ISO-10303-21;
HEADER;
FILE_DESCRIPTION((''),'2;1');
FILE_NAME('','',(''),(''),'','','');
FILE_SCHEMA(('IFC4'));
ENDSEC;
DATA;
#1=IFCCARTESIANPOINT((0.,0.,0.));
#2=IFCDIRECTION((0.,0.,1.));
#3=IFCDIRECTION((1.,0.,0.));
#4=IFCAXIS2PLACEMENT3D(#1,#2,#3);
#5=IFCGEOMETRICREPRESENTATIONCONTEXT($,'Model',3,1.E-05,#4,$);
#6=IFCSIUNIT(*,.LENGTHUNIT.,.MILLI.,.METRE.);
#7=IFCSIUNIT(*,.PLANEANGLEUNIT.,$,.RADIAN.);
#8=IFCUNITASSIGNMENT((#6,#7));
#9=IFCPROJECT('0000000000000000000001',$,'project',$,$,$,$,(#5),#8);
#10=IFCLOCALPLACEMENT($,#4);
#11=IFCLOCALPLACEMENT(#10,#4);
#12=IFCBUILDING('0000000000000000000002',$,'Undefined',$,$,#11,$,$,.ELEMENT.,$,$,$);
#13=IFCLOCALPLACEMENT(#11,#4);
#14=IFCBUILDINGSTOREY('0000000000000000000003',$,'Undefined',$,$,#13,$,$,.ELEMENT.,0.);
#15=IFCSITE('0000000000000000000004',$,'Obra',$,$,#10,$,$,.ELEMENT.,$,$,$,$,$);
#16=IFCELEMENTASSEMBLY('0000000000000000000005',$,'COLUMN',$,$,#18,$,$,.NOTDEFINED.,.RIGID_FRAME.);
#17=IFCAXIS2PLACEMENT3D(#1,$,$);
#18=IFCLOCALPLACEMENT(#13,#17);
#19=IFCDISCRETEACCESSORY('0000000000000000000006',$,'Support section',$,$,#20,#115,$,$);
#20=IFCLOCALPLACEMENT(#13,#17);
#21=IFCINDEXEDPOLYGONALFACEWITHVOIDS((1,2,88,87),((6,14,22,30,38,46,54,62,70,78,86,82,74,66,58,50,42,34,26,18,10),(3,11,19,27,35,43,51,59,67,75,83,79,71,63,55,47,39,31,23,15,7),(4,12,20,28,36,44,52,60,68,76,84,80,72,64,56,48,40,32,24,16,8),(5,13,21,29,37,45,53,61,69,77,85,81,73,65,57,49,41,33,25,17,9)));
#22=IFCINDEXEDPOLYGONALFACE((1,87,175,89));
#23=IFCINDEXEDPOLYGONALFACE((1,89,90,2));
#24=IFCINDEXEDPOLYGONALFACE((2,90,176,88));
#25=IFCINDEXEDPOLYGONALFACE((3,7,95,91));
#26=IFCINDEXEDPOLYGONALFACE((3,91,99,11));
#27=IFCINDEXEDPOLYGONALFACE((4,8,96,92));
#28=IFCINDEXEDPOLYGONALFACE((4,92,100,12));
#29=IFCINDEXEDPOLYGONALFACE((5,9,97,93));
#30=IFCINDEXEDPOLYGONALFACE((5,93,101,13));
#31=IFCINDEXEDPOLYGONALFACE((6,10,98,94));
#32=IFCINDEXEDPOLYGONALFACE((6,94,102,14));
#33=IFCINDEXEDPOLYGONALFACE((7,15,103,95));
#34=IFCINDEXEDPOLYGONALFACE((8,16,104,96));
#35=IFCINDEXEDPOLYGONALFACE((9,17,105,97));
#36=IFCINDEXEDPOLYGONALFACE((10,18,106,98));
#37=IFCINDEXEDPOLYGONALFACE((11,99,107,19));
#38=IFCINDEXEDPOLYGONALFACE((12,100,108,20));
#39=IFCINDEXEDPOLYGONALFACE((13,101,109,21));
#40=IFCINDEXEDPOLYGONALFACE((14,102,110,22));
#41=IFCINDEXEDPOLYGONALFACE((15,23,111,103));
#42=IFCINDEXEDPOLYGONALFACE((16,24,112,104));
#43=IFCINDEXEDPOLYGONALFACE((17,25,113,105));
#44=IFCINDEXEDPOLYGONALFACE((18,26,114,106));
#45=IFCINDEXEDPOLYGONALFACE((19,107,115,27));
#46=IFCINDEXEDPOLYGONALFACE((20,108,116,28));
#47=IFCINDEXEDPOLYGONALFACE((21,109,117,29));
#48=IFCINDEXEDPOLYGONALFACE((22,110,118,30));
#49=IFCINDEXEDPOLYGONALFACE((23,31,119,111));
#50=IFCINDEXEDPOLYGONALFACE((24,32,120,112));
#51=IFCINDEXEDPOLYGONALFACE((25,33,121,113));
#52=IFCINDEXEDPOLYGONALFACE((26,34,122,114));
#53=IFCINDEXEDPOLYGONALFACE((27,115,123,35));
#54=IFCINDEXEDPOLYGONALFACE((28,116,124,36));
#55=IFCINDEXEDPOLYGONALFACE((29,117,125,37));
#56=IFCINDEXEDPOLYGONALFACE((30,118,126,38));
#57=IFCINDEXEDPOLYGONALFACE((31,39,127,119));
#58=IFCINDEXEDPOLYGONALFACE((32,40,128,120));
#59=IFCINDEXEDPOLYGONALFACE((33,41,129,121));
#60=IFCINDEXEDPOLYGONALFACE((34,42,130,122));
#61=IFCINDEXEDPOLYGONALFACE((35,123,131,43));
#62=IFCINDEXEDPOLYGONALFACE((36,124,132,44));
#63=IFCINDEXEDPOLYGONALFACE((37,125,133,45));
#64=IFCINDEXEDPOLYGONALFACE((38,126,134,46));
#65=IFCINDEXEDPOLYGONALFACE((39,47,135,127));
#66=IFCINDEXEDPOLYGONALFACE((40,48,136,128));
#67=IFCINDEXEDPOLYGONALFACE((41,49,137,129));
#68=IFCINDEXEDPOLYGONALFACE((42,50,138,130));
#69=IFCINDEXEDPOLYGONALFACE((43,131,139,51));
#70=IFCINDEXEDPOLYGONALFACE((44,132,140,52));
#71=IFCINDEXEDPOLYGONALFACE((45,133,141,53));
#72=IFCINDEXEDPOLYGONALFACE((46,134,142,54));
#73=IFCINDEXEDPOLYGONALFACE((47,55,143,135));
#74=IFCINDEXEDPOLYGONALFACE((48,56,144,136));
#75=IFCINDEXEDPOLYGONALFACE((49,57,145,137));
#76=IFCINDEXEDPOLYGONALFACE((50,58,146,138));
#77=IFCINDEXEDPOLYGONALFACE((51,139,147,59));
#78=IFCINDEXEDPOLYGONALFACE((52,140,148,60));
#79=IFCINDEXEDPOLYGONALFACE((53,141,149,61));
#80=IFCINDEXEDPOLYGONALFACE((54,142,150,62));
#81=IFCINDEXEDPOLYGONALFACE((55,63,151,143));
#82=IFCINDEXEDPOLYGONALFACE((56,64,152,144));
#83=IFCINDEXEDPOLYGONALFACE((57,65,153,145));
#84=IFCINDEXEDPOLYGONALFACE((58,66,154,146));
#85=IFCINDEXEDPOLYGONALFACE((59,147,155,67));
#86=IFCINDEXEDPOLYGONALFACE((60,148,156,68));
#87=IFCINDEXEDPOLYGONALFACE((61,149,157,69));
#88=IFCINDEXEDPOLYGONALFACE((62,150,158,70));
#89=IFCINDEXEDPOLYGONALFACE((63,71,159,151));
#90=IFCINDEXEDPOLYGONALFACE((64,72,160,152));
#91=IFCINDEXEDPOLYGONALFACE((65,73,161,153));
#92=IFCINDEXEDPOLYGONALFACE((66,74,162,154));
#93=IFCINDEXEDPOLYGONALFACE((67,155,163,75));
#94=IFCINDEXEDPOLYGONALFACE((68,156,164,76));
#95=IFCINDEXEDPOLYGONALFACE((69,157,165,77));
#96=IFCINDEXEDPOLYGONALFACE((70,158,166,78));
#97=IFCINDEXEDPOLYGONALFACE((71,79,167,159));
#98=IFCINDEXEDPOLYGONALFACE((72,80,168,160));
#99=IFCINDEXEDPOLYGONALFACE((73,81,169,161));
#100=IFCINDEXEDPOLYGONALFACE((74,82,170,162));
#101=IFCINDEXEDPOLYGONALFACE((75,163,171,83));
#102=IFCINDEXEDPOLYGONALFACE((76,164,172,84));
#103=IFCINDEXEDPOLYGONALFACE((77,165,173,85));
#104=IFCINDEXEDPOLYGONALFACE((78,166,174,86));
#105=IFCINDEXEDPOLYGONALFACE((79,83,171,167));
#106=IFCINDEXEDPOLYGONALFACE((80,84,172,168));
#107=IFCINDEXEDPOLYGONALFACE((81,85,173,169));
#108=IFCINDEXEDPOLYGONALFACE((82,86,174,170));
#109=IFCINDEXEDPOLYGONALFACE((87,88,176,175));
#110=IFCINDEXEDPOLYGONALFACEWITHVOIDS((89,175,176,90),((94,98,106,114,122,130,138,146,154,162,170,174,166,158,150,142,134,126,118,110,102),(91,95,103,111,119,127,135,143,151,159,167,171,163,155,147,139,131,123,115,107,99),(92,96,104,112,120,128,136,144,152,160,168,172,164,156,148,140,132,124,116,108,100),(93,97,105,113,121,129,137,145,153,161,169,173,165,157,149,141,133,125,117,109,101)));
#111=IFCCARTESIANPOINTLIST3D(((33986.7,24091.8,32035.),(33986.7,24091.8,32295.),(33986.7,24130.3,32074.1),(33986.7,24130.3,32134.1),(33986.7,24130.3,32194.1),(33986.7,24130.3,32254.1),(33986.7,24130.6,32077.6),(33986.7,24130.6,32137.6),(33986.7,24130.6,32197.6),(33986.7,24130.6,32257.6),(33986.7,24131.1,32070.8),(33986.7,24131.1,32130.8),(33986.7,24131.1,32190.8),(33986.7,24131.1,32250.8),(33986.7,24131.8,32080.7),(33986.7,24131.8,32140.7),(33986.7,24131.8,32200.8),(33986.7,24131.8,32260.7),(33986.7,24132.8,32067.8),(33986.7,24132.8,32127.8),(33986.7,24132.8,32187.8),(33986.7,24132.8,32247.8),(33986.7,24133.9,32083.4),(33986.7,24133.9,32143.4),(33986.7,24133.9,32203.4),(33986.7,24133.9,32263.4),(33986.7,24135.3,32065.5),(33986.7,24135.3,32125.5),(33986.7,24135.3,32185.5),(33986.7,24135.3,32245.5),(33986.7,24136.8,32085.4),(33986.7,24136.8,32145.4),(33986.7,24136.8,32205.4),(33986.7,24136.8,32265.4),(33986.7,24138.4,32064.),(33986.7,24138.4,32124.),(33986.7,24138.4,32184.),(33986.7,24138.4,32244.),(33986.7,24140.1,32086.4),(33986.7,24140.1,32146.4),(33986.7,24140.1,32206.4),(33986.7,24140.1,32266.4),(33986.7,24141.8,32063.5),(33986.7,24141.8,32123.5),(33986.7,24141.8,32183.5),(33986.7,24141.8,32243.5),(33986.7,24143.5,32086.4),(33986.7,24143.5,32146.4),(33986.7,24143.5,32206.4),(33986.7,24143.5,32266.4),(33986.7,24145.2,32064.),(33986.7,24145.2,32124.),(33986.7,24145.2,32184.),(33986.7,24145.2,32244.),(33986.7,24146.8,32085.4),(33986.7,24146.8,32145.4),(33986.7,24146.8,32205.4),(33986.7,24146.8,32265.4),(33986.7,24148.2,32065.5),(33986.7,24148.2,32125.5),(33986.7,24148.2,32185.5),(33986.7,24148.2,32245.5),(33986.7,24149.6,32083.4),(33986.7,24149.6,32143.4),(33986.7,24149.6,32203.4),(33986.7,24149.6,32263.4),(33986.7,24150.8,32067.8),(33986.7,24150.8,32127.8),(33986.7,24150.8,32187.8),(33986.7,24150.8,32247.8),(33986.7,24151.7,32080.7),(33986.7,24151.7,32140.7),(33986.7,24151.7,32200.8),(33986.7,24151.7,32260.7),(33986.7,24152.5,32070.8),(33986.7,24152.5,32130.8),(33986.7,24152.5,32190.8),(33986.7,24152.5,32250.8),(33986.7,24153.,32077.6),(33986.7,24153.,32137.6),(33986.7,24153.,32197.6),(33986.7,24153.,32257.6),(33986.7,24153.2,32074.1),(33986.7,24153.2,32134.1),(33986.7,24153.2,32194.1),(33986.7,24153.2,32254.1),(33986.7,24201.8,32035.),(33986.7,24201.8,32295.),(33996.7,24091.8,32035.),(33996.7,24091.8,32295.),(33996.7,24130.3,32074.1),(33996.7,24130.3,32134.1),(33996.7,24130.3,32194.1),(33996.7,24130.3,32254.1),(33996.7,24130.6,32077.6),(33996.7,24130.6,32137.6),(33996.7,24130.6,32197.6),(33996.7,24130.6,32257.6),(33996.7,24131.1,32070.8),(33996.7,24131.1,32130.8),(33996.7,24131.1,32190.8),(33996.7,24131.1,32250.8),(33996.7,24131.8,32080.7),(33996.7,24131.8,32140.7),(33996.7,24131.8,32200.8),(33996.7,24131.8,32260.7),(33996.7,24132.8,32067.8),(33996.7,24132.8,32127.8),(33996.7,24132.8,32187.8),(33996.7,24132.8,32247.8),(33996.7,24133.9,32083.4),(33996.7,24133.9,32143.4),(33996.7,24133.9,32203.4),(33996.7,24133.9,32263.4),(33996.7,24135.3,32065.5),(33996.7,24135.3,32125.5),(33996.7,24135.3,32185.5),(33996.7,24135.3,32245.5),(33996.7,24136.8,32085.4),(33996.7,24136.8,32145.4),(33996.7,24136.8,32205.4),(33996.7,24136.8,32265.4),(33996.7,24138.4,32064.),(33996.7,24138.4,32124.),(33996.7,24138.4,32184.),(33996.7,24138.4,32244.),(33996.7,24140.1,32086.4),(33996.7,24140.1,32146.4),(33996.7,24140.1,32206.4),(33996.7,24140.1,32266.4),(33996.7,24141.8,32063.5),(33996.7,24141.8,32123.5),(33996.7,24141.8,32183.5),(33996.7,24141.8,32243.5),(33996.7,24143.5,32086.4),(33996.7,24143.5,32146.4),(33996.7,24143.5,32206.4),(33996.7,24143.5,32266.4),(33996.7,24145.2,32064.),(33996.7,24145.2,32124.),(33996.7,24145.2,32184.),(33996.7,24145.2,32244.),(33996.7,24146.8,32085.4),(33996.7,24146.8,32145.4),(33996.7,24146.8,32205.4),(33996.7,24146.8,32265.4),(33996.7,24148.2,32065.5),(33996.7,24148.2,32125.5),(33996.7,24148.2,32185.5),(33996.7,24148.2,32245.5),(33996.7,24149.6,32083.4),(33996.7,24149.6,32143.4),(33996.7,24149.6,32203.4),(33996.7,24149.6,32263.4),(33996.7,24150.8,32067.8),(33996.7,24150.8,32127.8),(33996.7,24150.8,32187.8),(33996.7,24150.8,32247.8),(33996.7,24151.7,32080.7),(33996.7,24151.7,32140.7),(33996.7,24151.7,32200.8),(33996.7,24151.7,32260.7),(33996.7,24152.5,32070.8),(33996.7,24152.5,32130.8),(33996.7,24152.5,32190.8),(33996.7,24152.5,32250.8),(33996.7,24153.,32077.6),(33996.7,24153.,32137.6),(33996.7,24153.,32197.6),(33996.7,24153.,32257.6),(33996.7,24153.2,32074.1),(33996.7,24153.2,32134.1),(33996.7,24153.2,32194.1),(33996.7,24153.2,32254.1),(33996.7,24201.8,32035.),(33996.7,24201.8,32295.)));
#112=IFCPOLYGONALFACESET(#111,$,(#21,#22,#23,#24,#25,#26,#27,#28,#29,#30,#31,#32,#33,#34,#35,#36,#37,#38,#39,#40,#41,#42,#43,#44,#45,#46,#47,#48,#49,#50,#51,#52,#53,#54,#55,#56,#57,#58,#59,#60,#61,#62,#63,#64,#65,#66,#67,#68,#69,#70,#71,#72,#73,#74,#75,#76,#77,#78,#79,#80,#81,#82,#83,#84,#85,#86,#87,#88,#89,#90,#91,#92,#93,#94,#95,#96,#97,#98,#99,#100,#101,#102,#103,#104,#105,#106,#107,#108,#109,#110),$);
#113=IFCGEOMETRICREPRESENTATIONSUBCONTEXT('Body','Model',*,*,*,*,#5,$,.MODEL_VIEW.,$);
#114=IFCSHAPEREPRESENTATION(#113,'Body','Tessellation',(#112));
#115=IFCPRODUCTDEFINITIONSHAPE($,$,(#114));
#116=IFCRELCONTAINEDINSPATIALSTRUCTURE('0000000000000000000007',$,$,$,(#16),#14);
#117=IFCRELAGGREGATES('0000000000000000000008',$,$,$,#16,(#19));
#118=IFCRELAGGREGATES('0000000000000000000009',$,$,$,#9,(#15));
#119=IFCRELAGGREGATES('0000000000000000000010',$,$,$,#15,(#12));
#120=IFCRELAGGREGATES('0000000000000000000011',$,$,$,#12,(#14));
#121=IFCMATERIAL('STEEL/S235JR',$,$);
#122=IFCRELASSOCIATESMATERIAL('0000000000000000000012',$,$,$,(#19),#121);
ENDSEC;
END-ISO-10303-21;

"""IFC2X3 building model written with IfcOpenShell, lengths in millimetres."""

from ifc_helpers import new_model, si_unit, frame, origin_with_axes, origin_2d_with_axis, place, context, subcontext, project, spatial, rectangle, circle, extrude, source, transform, mapped, material, element, aggregate, save


model = new_model("IFC2X3")

# Units and contexts
model_context = context("Model", 3, precision=1e-05, world=origin_with_axes())
body_context = subcontext(model_context, "Body", "Model", "MODEL_VIEW")
ifc_project = project(units=[si_unit("LENGTHUNIT", "METRE", prefix="MILLI"), si_unit("PLANEANGLEUNIT", "RADIAN")], contexts=[model_context])

# Site, building, storey
site_placement = place(None, origin_with_axes())
site = spatial("IfcSite", under=ifc_project, at=site_placement, Name="Obra", CompositionType="ELEMENT")
building_placement = place(site_placement, origin_with_axes())
building = spatial("IfcBuilding", under=site, at=building_placement, Name="Undefined", CompositionType="ELEMENT")
storey_placement = place(building_placement, origin_with_axes())
storey = spatial("IfcBuildingStorey", under=building, at=storey_placement, Name="Undefined", CompositionType="ELEMENT", Elevation=0.0)

# Shared definitions
ifc_material_1 = material(Name="STEEL/S235JR")

# Element assembly, discrete accessory, opening
assembly_1_placement = place(storey_placement, origin_with_axes())
assembly_1 = element("IfcElementAssembly", 1, at=assembly_1_placement, inside=storey, Name="COLUMN", AssemblyPlace="NOTDEFINED", PredefinedType="RIGID_FRAME")
discrete_accessory_1_placement = place(assembly_1_placement, frame((33991.7, 24146.8, 32035.0), z_axis=(0.0, 0.0, 1.0), x_axis=(0.0, 1.0, 0.0)))
discrete_accessory_1 = element("IfcDiscreteAccessory", 2, at=discrete_accessory_1_placement, material=ifc_material_1, Name="Support section", context=body_context, shape_type="SweptSolid", body=[
    extrude(rectangle(XDim=10.0, YDim=110.0, at=origin_2d_with_axis()), frame((0.0, 0.0, 260.0), z_axis=(0.0, 0.0, -1.0), x_axis=(0.0, 1.0, 0.0)), (0.0, 0.0, 1.0), 260.0),
])
shared_shape_1 = source(origin_with_axes(), body_context, "Body", "SweptSolid", [
    extrude(circle(Radius=11.5, at=origin_2d_with_axis()), frame((0.0, -13.4, 0.0), z_axis=(0.0, 1.0, 0.0), x_axis=(1.0, 0.0, 0.0)), (0.0, 0.0, 1.0), 10.2),
])
opening_1_placement = place(assembly_1_placement, frame((34000.0, 24191.8, 32300.0), z_axis=(0.0, -1.0, 0.0), x_axis=(0.0, 0.0, -1.0)))
element("IfcOpeningElement", 3, at=opening_1_placement, cuts=discrete_accessory_1, ObjectType="Opening", context=body_context, shape_type="MappedRepresentation", body=[
    mapped(shared_shape_1, transform((45.0, 0.0, 50.0))),
    mapped(shared_shape_1, transform((105.0, 0.0, 50.0))),
    mapped(shared_shape_1, transform((165.0, 0.0, 50.0))),
    mapped(shared_shape_1, transform((225.0, 0.0, 50.0))),
])
aggregate(assembly_1, [discrete_accessory_1])

save(model, "model.ifc")
